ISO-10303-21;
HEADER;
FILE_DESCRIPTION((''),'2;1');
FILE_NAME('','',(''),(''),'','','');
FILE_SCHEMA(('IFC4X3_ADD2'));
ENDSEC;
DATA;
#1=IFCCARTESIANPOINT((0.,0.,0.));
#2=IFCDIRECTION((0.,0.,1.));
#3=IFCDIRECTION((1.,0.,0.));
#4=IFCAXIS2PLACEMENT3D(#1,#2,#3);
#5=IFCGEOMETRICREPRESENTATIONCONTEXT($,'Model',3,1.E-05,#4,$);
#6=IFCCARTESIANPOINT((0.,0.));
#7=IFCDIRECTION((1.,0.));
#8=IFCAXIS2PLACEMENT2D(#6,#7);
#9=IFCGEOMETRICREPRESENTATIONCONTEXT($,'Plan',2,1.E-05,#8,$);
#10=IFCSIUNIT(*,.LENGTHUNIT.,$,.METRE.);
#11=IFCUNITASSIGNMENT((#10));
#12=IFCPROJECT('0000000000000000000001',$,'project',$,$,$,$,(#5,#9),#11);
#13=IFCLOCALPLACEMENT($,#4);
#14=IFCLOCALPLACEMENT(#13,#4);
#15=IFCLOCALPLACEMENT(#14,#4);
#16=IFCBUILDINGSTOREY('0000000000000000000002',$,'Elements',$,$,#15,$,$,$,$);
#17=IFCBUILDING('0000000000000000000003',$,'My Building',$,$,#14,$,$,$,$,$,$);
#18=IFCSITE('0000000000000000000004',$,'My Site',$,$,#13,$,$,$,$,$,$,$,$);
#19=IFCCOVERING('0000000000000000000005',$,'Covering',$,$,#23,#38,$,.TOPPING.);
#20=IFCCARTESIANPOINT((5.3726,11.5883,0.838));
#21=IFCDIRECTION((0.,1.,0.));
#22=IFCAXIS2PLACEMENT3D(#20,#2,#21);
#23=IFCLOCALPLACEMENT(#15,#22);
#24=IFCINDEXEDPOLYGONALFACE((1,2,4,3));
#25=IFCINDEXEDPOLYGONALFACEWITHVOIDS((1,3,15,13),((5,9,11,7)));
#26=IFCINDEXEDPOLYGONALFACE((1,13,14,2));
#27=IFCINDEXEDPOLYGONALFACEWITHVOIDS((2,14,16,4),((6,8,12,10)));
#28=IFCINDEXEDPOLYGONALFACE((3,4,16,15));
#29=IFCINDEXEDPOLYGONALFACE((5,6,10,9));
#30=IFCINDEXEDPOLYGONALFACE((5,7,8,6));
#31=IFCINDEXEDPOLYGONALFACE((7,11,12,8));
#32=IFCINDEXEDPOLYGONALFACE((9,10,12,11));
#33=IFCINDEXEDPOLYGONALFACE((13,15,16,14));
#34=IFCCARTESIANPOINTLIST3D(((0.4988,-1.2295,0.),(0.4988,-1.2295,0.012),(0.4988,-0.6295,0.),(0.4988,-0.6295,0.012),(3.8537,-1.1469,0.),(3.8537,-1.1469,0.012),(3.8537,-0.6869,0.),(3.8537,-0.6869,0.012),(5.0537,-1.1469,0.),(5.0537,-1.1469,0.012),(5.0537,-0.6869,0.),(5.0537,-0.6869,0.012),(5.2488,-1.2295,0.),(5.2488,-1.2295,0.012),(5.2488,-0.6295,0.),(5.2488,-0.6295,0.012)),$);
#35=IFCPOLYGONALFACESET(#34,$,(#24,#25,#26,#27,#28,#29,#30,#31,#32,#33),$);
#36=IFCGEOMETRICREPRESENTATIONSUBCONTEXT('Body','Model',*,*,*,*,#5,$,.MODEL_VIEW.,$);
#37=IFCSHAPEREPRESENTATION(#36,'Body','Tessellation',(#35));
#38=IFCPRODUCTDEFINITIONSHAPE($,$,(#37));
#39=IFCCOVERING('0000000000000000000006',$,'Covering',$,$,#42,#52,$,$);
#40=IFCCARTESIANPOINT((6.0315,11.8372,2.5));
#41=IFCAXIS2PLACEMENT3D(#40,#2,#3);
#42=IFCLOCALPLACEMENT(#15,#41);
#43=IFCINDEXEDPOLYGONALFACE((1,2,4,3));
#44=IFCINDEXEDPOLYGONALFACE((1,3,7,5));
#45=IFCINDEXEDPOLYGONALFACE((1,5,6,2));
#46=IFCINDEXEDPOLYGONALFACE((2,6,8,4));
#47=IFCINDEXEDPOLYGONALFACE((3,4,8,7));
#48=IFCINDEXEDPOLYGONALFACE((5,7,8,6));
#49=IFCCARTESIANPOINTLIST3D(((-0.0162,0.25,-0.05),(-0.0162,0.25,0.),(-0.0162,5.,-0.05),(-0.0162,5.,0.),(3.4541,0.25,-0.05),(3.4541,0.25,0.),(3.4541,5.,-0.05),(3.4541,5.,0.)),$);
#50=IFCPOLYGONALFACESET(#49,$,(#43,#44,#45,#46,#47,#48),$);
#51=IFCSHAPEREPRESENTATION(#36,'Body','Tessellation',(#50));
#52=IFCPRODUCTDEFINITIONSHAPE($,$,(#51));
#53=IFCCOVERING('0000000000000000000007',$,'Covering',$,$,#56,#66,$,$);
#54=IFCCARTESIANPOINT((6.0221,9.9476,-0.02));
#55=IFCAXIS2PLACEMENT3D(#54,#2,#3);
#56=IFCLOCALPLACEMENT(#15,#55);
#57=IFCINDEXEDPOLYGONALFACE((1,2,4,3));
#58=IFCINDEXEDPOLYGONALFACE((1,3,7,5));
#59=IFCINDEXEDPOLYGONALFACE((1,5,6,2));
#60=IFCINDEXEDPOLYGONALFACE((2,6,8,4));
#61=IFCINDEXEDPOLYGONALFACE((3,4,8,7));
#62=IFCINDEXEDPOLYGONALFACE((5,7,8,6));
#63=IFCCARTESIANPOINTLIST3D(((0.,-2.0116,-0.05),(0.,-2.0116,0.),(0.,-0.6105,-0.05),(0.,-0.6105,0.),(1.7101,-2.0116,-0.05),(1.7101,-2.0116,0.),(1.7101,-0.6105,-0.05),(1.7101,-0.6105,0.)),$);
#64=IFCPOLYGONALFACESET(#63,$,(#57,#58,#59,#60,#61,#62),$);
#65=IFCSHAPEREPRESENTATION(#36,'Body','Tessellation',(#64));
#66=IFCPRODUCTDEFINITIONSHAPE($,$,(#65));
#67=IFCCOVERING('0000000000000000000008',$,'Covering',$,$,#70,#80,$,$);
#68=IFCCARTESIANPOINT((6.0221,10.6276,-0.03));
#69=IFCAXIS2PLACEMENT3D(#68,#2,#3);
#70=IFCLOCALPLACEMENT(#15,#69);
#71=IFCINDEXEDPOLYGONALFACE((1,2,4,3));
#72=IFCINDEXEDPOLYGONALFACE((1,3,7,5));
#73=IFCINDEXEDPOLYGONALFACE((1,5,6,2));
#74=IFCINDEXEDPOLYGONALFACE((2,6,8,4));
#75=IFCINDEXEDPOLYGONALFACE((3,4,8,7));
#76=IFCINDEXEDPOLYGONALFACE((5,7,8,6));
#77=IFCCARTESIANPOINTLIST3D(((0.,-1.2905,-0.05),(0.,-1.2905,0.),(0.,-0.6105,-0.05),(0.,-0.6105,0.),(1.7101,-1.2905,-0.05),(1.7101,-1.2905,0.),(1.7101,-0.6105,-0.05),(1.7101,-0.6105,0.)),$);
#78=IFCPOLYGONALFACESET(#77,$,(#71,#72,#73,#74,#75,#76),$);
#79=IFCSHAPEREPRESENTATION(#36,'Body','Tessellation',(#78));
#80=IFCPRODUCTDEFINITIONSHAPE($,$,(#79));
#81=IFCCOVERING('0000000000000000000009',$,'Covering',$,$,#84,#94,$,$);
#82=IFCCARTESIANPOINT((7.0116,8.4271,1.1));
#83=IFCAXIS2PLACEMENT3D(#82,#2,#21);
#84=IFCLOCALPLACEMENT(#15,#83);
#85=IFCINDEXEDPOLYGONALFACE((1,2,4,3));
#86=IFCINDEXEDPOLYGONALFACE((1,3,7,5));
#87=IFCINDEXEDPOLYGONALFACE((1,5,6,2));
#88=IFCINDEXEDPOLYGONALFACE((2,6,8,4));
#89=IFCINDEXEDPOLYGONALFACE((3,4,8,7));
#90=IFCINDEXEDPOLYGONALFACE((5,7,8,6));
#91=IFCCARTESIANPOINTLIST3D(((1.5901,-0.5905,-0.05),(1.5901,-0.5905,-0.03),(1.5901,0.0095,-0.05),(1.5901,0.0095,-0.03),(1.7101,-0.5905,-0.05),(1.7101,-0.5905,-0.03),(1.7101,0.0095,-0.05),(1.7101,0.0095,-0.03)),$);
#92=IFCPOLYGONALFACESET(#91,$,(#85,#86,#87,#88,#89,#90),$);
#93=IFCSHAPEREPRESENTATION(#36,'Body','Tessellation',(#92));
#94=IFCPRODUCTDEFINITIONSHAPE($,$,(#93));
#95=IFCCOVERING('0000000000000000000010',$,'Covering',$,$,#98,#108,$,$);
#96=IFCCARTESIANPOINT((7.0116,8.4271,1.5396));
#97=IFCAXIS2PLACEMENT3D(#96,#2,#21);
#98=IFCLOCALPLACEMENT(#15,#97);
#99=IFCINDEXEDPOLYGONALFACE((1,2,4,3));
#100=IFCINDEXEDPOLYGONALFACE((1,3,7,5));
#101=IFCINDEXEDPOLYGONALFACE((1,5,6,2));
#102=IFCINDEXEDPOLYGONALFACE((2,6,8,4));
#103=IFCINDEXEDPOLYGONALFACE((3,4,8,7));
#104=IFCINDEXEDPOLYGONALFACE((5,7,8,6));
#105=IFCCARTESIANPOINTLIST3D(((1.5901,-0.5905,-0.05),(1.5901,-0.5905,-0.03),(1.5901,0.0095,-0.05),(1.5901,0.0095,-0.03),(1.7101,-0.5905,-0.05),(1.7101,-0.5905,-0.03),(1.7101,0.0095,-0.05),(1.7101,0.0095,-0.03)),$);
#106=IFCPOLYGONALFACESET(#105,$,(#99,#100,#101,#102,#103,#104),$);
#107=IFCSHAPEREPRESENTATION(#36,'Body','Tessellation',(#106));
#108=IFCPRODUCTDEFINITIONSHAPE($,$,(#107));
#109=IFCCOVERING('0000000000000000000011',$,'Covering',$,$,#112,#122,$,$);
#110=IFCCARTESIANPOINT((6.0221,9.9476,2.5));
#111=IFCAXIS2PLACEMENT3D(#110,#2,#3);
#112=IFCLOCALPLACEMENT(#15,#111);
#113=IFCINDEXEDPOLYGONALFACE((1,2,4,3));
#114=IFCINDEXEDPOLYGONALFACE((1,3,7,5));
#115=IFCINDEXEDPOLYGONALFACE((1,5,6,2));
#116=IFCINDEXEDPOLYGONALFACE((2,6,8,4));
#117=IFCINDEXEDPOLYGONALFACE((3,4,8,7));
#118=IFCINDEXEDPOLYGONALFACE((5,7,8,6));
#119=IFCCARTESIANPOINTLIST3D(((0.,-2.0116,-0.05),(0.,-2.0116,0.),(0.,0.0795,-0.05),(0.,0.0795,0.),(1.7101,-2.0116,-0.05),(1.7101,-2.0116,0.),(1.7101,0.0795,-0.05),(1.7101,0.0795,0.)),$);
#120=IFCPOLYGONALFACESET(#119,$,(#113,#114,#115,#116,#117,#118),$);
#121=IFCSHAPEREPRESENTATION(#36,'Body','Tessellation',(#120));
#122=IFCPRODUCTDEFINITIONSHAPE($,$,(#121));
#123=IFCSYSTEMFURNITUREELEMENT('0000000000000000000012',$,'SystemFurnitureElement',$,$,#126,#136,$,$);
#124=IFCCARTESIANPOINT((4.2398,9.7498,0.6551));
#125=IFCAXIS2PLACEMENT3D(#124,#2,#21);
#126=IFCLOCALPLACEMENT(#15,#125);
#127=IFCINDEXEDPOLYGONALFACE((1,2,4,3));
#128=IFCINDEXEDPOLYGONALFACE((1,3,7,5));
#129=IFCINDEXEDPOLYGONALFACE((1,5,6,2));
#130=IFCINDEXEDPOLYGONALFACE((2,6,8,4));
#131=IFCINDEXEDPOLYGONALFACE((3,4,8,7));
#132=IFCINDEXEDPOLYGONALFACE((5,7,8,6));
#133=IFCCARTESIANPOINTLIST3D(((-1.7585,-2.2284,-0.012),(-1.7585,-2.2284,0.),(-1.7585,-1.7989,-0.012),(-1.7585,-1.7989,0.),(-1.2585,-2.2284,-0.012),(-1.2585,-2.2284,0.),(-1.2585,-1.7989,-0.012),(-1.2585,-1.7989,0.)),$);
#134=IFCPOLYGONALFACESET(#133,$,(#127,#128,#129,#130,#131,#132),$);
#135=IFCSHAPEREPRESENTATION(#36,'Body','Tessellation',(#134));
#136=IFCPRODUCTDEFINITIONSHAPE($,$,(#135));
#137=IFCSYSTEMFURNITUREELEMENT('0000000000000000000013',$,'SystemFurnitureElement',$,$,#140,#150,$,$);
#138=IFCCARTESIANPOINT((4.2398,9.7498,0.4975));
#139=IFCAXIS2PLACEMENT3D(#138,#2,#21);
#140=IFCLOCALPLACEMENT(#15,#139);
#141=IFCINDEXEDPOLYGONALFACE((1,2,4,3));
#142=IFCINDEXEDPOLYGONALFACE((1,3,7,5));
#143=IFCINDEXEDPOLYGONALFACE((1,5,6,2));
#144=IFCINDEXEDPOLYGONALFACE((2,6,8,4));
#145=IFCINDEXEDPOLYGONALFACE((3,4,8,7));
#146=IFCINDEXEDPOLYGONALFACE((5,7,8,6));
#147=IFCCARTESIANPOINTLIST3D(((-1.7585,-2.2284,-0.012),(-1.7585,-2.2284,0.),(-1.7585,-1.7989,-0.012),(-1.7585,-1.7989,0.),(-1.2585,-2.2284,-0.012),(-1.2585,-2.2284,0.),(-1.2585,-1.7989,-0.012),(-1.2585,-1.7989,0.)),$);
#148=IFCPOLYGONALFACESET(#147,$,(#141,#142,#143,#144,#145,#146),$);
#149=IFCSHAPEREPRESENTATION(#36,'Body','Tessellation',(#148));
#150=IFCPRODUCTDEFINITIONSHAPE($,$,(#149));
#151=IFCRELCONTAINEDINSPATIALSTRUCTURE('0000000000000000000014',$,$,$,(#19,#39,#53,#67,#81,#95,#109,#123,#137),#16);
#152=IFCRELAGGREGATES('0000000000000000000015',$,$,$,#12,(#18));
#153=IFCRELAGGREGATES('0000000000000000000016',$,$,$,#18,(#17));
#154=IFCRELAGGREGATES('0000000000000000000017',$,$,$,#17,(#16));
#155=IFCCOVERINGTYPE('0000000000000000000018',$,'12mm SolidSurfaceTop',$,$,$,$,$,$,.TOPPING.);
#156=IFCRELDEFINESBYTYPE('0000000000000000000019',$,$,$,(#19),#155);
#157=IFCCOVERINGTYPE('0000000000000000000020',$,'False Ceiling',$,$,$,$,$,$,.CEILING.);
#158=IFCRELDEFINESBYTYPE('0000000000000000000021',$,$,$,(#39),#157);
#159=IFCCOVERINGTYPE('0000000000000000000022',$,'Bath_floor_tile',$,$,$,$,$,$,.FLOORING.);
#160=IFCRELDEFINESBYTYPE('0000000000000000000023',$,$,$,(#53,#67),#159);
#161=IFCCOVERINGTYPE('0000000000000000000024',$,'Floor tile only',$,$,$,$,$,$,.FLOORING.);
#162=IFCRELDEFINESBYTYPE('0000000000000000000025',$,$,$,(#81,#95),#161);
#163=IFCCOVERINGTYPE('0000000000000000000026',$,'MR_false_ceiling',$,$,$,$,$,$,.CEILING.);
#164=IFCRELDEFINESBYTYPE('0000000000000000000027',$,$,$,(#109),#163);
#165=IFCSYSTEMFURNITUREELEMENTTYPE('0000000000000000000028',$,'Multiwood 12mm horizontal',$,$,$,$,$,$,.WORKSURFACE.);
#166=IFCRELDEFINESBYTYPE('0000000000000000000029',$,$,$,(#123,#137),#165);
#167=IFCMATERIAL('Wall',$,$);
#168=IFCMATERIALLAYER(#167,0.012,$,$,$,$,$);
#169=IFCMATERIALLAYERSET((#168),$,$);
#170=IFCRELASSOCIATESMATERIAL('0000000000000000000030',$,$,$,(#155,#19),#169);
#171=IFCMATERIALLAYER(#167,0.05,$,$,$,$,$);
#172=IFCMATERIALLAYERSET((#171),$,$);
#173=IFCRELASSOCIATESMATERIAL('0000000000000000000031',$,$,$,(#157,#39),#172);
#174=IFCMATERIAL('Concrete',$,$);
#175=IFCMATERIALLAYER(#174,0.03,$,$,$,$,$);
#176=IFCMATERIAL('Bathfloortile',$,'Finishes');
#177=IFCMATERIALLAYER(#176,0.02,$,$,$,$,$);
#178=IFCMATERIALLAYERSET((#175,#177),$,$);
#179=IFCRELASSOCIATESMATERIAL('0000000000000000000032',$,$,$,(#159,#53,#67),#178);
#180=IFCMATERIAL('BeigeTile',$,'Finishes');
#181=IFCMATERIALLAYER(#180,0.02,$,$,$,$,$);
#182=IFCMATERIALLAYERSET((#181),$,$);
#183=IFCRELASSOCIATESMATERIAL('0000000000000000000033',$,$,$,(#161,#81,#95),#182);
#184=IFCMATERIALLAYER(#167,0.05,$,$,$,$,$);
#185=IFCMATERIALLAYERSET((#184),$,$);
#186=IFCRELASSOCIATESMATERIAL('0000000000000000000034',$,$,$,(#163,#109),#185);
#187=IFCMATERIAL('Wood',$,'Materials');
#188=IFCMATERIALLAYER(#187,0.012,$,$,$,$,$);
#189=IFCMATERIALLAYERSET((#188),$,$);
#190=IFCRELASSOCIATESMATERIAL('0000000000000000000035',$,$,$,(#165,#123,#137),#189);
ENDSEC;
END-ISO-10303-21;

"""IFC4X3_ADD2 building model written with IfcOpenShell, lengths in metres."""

from ifc_helpers import new_model, si_unit, frame, origin_with_axes, origin_2d_with_axis, place, context, subcontext, project, spatial, indexed_curve, outline, extrude, material, layer, layer_set, layer_usage, type_object, element, save


model = new_model("IFC4X3_ADD2")

# Units and contexts
model_context = context("Model", 3, precision=1e-05, world=origin_with_axes())
plan_context = context("Plan", 2, precision=1e-05, world=origin_2d_with_axis())
body_context = subcontext(model_context, "Body", "Model", "MODEL_VIEW")
ifc_project = project(units=[si_unit("LENGTHUNIT", "METRE")], contexts=[model_context, plan_context])

# Site, building, storey
site_placement = place(None, origin_with_axes())
site = spatial("IfcSite", under=ifc_project, at=site_placement, Name="My Site")
building_placement = place(site_placement, origin_with_axes())
building = spatial("IfcBuilding", under=site, at=building_placement, Name="My Building")
storey_placement = place(building_placement, origin_with_axes())
storey = spatial("IfcBuildingStorey", under=building, at=storey_placement, Name="Elements")

# Covering
ifc_material_1 = material(Name="Wall")
ifc_layer_1 = layer(ifc_material_1, 0.012)
ifc_layer_set_1 = layer_set([ifc_layer_1])
ifc_layer_usage_1 = layer_usage(ifc_layer_set_1, "AXIS3", "POSITIVE", 0.0)
covering_type_1 = type_object("IfcCoveringType", Name="12mm SolidSurfaceTop", PredefinedType="TOPPING", material=ifc_layer_set_1)
covering_1_placement = place(storey_placement, frame((5.3726, 11.5883, 0.838), z_axis=(0.0, 0.0, 1.0), x_axis=(0.0, 1.0, 0.0)))
element("IfcCovering", 1, at=covering_1_placement, inside=storey, type_object=covering_type_1, material=ifc_layer_usage_1, Name="Covering", PredefinedType="TOPPING", context=body_context, shape_type="SweptSolid", body=[
    extrude(outline(indexed_curve([(0.4988, -1.2295), (5.2488, -1.2295), (5.2488, -0.6295), (0.4988, -0.6295), (0.4988, -1.2295)]), holes=[indexed_curve([(3.8537, -1.1469), (5.0537, -1.1469), (5.0537, -0.6869), (3.8537, -0.6869), (3.8537, -1.1469)])]), None, (0.0, 0.0, 1.0), 0.012),
])

# Coverings
ifc_layer_2 = layer(ifc_material_1, 0.05)
ifc_layer_set_2 = layer_set([ifc_layer_2])
ifc_layer_usage_2 = layer_usage(ifc_layer_set_2, "AXIS3", "POSITIVE", -0.05)
covering_type_2 = type_object("IfcCoveringType", Name="False Ceiling", PredefinedType="CEILING", material=ifc_layer_set_2)
covering_2_placement = place(storey_placement, frame((6.0315, 11.8372, 2.5), z_axis=(0.0, 0.0, 1.0), x_axis=(1.0, 0.0, 0.0)))
element("IfcCovering", 2, at=covering_2_placement, inside=storey, type_object=covering_type_2, material=ifc_layer_usage_2, Name="Covering", context=body_context, shape_type="SweptSolid", body=[
    extrude(outline(indexed_curve([(-0.0162, 5.0), (3.4541, 5.0), (3.4541, 0.25), (-0.0162, 0.25), (-0.0162, 5.0)])), frame((0.0, 0.0, -0.05), z_axis=(0.0, 0.0, 1.0), x_axis=(1.0, 0.0, 0.0)), (0.0, 0.0, 1.0), 0.05),
])
ifc_material_2 = material(Name="Concrete")
ifc_layer_3 = layer(ifc_material_2, 0.03)
ifc_material_3 = material(Name="Bathfloortile", Category="Finishes")
ifc_layer_4 = layer(ifc_material_3, 0.02)
ifc_layer_set_3 = layer_set([ifc_layer_3, ifc_layer_4])
ifc_layer_usage_3 = layer_usage(ifc_layer_set_3, "AXIS3", "POSITIVE", -0.05)
covering_type_3 = type_object("IfcCoveringType", Name="Bath_floor_tile", PredefinedType="FLOORING", material=ifc_layer_set_3)
covering_3_placement = place(storey_placement, frame((6.0221, 9.9476, -0.02), z_axis=(0.0, 0.0, 1.0), x_axis=(1.0, 0.0, 0.0)))
element("IfcCovering", 3, at=covering_3_placement, inside=storey, type_object=covering_type_3, material=ifc_layer_usage_3, Name="Covering", context=body_context, shape_type="SweptSolid", body=[
    extrude(outline(indexed_curve([(0.0, -0.6105), (1.7101, -0.6105), (1.7101, -2.0116), (0.0, -2.0116), (0.0, -0.6105)])), frame((0.0, 0.0, -0.05), z_axis=(0.0, 0.0, 1.0), x_axis=(1.0, 0.0, 0.0)), (0.0, 0.0, 1.0), 0.05),
])
ifc_layer_usage_4 = layer_usage(ifc_layer_set_3, "AXIS3", "POSITIVE", -0.05)
covering_4_placement = place(storey_placement, frame((6.0221, 10.6276, -0.03), z_axis=(0.0, 0.0, 1.0), x_axis=(1.0, 0.0, 0.0)))
element("IfcCovering", 4, at=covering_4_placement, inside=storey, type_object=covering_type_3, material=ifc_layer_usage_4, Name="Covering", context=body_context, shape_type="SweptSolid", body=[
    extrude(outline(indexed_curve([(0.0, -1.2905), (1.7101, -1.2905), (1.7101, -0.6105), (0.0, -0.6105), (0.0, -1.2905)])), frame((0.0, 0.0, -0.05), z_axis=(0.0, 0.0, 1.0), x_axis=(1.0, 0.0, 0.0)), (0.0, 0.0, 1.0), 0.05),
])
ifc_material_4 = material(Name="BeigeTile", Category="Finishes")
ifc_layer_5 = layer(ifc_material_4, 0.02)
ifc_layer_set_4 = layer_set([ifc_layer_5])
ifc_layer_usage_5 = layer_usage(ifc_layer_set_4, "AXIS3", "POSITIVE", -0.05)
covering_type_4 = type_object("IfcCoveringType", Name="Floor tile only", PredefinedType="FLOORING", material=ifc_layer_set_4)
covering_5_placement = place(storey_placement, frame((7.0116, 8.4271, 1.1), z_axis=(0.0, 0.0, 1.0), x_axis=(0.0, 1.0, 0.0)))
element("IfcCovering", 5, at=covering_5_placement, inside=storey, type_object=covering_type_4, material=ifc_layer_usage_5, Name="Covering", context=body_context, shape_type="SweptSolid", body=[
    extrude(outline(indexed_curve([(1.5901, 0.0095), (1.5901, -0.5905), (1.7101, -0.5905), (1.7101, 0.0095), (1.5901, 0.0095)])), frame((0.0, 0.0, -0.05), z_axis=(0.0, 0.0, 1.0), x_axis=(1.0, 0.0, 0.0)), (0.0, 0.0, 1.0), 0.02),
])
ifc_layer_usage_6 = layer_usage(ifc_layer_set_4, "AXIS3", "POSITIVE", -0.05)
covering_6_placement = place(storey_placement, frame((7.0116, 8.4271, 1.5396), z_axis=(0.0, 0.0, 1.0), x_axis=(0.0, 1.0, 0.0)))
element("IfcCovering", 6, at=covering_6_placement, inside=storey, type_object=covering_type_4, material=ifc_layer_usage_6, Name="Covering", context=body_context, shape_type="SweptSolid", body=[
    extrude(outline(indexed_curve([(1.5901, 0.0095), (1.5901, -0.5905), (1.7101, -0.5905), (1.7101, 0.0095), (1.5901, 0.0095)])), frame((0.0, 0.0, -0.05), z_axis=(0.0, 0.0, 1.0), x_axis=(1.0, 0.0, 0.0)), (0.0, 0.0, 1.0), 0.02),
])
ifc_layer_6 = layer(ifc_material_1, 0.05)
ifc_layer_set_5 = layer_set([ifc_layer_6])
ifc_layer_usage_7 = layer_usage(ifc_layer_set_5, "AXIS3", "POSITIVE", -0.05)
covering_type_5 = type_object("IfcCoveringType", Name="MR_false_ceiling", PredefinedType="CEILING", material=ifc_layer_set_5)
covering_7_placement = place(storey_placement, frame((6.0221, 9.9476, 2.5), z_axis=(0.0, 0.0, 1.0), x_axis=(1.0, 0.0, 0.0)))
element("IfcCovering", 7, at=covering_7_placement, inside=storey, type_object=covering_type_5, material=ifc_layer_usage_7, Name="Covering", context=body_context, shape_type="SweptSolid", body=[
    extrude(outline(indexed_curve([(0.0, -2.0116), (1.7101, -2.0116), (1.7101, 0.0795), (0.0, 0.0795), (0.0, -2.0116)])), frame((0.0, 0.0, -0.05), z_axis=(0.0, 0.0, 1.0), x_axis=(1.0, 0.0, 0.0)), (0.0, 0.0, 1.0), 0.05),
])

# System furniture elements
ifc_material_5 = material(Name="Wood", Category="Materials")
ifc_layer_7 = layer(ifc_material_5, 0.012)
ifc_layer_set_6 = layer_set([ifc_layer_7])
ifc_layer_usage_8 = layer_usage(ifc_layer_set_6, "AXIS3", "POSITIVE", -0.012)
system_furniture_element_type_1 = type_object("IfcSystemFurnitureElementType", Name="Multiwood 12mm horizontal", PredefinedType="WORKSURFACE", material=ifc_layer_set_6)
system_furniture_element_1_placement = place(storey_placement, frame((4.2398, 9.7498, 0.6551), z_axis=(0.0, 0.0, 1.0), x_axis=(0.0, 1.0, 0.0)))
element("IfcSystemFurnitureElement", 8, at=system_furniture_element_1_placement, inside=storey, type_object=system_furniture_element_type_1, material=ifc_layer_usage_8, Name="SystemFurnitureElement", context=body_context, shape_type="SweptSolid", body=[
    extrude(outline(indexed_curve([(-1.7585, -1.7989), (-1.7585, -2.2284), (-1.2585, -2.2284), (-1.2585, -1.7989), (-1.7585, -1.7989)])), frame((0.0, 0.0, -0.012), z_axis=(0.0, 0.0, 1.0), x_axis=(1.0, 0.0, 0.0)), (0.0, 0.0, 1.0), 0.012),
])
ifc_layer_usage_9 = layer_usage(ifc_layer_set_6, "AXIS3", "POSITIVE", -0.012)
system_furniture_element_2_placement = place(storey_placement, frame((4.2398, 9.7498, 0.4975), z_axis=(0.0, 0.0, 1.0), x_axis=(0.0, 1.0, 0.0)))
element("IfcSystemFurnitureElement", 9, at=system_furniture_element_2_placement, inside=storey, type_object=system_furniture_element_type_1, material=ifc_layer_usage_9, Name="SystemFurnitureElement", context=body_context, shape_type="SweptSolid", body=[
    extrude(outline(indexed_curve([(-1.7585, -1.7989), (-1.7585, -2.2284), (-1.2585, -2.2284), (-1.2585, -1.7989), (-1.7585, -1.7989)])), frame((0.0, 0.0, -0.012), z_axis=(0.0, 0.0, 1.0), x_axis=(1.0, 0.0, 0.0)), (0.0, 0.0, 1.0), 0.012),
])

save(model, "model.ifc")
